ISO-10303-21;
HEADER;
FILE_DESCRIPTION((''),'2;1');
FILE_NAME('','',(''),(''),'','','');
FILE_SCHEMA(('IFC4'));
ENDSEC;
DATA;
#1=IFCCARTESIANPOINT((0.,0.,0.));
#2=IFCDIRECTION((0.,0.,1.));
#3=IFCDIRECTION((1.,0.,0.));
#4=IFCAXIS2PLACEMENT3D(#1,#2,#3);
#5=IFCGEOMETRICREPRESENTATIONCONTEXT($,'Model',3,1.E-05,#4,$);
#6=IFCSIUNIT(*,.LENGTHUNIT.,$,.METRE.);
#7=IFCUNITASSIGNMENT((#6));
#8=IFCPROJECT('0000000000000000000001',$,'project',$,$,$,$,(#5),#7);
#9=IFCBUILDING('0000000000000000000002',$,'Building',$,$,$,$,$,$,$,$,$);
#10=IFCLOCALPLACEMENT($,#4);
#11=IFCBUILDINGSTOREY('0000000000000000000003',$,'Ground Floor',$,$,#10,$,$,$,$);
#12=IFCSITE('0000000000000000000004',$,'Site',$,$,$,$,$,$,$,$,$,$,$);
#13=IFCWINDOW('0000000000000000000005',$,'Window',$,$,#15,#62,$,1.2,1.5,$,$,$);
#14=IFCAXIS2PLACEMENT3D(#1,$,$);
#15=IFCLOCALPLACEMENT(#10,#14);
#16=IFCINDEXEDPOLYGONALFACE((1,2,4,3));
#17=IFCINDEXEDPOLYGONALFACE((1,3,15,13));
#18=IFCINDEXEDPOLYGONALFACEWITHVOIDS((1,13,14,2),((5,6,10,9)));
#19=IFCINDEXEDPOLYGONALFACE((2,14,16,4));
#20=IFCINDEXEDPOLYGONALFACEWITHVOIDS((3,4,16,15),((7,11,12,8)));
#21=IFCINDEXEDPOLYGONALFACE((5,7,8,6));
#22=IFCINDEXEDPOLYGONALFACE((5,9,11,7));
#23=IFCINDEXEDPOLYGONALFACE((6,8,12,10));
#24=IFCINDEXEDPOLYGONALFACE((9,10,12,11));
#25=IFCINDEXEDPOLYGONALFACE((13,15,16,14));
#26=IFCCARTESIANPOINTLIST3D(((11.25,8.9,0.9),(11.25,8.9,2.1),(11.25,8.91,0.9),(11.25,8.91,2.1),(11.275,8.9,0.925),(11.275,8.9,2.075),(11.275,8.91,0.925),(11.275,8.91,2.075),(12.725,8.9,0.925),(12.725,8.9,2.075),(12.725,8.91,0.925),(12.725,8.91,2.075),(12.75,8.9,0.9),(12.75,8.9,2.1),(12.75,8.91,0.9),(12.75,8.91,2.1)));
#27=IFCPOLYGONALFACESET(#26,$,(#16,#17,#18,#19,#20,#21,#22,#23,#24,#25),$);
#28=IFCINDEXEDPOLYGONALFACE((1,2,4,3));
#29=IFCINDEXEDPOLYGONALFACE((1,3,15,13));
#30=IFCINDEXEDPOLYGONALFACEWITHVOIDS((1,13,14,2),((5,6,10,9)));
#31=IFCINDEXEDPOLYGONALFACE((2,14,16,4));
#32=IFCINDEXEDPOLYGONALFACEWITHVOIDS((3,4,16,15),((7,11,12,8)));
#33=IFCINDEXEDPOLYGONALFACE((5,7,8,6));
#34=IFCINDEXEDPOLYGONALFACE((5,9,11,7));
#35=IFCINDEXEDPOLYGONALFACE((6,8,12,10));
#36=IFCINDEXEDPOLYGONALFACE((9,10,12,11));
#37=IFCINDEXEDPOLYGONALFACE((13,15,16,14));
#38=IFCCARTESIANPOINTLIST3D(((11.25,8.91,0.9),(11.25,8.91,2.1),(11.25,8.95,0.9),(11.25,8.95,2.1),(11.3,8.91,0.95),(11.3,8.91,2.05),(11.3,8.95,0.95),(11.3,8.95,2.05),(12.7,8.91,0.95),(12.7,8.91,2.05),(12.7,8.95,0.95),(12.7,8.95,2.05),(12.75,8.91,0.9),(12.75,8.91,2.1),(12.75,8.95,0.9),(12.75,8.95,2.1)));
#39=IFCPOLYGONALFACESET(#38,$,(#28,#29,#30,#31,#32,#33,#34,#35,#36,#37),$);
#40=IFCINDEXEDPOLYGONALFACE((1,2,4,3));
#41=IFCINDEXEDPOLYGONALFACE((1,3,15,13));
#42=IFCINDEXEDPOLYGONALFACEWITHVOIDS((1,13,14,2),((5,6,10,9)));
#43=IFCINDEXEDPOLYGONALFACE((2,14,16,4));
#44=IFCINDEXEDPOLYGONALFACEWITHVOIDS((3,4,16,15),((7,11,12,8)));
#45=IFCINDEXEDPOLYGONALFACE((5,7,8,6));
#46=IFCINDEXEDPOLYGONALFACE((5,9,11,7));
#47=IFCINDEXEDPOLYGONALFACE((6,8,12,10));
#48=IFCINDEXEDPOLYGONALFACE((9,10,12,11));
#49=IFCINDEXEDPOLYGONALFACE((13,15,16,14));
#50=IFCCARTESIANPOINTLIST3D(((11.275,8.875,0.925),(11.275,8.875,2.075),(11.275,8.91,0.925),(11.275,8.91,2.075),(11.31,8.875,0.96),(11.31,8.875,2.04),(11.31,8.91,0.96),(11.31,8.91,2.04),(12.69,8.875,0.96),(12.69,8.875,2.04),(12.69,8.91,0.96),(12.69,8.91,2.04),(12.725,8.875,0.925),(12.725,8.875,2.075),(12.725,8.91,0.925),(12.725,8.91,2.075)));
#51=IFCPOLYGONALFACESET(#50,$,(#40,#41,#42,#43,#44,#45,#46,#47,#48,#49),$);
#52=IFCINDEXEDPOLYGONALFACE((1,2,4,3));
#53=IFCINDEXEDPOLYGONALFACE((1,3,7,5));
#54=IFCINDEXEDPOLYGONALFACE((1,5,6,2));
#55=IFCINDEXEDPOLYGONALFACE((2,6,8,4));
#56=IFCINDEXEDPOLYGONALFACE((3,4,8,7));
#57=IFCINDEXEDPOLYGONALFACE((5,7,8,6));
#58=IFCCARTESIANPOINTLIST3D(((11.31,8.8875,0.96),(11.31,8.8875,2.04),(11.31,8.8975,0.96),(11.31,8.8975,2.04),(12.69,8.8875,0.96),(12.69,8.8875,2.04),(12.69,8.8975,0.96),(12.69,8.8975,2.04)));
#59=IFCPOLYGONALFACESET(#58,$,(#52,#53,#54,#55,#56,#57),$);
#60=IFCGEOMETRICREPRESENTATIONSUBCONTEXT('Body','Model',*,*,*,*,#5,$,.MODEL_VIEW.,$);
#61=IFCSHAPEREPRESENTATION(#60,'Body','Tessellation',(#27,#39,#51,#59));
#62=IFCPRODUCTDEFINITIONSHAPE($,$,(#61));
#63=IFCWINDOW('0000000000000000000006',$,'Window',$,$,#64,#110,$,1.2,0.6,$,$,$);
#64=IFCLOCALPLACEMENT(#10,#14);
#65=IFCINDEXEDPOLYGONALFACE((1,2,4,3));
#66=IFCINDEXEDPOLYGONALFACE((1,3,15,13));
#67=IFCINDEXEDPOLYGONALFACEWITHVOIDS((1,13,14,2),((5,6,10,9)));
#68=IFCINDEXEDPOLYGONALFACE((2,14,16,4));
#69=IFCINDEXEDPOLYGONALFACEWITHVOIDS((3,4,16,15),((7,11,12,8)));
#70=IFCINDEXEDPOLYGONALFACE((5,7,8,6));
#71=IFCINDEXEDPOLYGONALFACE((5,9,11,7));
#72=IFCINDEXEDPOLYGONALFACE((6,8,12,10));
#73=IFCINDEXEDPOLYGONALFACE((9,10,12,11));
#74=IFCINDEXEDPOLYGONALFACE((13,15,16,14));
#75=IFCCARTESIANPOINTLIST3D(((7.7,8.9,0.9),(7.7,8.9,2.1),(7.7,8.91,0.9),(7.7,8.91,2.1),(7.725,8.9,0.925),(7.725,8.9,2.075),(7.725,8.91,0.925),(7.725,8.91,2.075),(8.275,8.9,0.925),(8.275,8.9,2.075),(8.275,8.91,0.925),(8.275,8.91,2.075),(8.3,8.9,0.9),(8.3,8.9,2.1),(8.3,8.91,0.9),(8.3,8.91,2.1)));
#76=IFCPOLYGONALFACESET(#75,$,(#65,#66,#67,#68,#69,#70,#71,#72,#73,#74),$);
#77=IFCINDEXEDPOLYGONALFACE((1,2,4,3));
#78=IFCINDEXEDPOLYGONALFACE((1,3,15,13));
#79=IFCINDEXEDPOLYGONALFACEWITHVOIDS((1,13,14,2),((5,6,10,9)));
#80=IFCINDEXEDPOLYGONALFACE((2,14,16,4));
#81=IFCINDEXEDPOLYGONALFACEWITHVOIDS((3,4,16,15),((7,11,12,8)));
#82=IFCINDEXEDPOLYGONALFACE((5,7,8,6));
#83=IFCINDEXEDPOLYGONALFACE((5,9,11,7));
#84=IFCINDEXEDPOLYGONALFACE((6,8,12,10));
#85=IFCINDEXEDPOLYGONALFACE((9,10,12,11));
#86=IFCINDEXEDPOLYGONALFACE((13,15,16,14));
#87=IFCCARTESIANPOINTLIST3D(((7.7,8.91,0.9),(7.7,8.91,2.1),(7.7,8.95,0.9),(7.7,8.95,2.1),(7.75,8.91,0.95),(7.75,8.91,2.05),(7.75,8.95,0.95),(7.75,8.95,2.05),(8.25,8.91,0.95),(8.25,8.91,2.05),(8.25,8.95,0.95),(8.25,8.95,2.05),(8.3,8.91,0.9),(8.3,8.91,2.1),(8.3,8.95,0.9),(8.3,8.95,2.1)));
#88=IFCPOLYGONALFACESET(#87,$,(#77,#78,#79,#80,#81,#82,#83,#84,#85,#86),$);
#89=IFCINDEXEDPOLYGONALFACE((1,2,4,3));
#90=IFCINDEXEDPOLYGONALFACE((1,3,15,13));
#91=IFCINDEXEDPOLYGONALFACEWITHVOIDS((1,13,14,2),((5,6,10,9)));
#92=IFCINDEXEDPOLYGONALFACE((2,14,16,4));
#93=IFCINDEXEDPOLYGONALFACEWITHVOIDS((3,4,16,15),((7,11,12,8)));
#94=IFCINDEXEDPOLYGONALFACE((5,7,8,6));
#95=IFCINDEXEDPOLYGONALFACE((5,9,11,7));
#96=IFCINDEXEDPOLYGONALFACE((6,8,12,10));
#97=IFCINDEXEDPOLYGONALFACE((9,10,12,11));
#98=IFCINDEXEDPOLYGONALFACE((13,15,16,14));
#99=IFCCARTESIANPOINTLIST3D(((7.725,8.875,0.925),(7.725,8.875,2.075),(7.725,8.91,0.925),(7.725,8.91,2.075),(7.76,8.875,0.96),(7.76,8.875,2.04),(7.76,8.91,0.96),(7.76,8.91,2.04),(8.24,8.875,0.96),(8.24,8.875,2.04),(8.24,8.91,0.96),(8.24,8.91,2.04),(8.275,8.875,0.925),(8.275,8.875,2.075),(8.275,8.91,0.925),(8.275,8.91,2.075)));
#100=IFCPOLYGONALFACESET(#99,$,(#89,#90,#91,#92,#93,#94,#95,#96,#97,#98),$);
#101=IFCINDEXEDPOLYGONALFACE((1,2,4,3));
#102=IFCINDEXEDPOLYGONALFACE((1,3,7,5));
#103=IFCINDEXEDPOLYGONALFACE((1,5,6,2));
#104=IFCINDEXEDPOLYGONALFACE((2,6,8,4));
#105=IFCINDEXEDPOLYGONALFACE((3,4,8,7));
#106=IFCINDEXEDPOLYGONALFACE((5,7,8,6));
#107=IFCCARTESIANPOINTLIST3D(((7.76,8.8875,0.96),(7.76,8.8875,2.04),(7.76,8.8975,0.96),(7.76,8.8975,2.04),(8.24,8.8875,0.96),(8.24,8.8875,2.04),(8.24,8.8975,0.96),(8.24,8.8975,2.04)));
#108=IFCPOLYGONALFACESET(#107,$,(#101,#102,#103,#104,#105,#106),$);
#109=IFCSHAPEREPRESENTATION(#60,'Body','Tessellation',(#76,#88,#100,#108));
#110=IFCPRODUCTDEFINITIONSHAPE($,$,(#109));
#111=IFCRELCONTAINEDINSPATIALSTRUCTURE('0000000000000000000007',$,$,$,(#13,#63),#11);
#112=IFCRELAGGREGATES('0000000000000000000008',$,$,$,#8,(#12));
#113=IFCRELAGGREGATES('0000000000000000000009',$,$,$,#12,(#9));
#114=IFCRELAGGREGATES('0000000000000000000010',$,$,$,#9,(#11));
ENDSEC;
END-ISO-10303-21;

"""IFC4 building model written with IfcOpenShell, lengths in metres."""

from ifc_helpers import new_model, si_unit, frame, origin_with_axes, place, context, subcontext, project, spatial, line, indexed_curve, outline, extrude, element, save


model = new_model("IFC4")

# Units and contexts
model_context = context("Model", 3, precision=1e-05, world=origin_with_axes())
body_context = subcontext(model_context, "Body", "Model", "MODEL_VIEW")
ifc_project = project(units=[si_unit("LENGTHUNIT", "METRE")], contexts=[model_context])

# Site, building, storey
site = spatial("IfcSite", under=ifc_project, Name="Site")
building = spatial("IfcBuilding", under=site, Name="Building")
storey_placement = place(None, origin_with_axes())
storey = spatial("IfcBuildingStorey", under=building, at=storey_placement, Name="Ground Floor")

# Windows
window_1_placement = place(storey_placement, frame((12.75, 9.0, 0.9), z_axis=(0.0, 0.0, 1.0), x_axis=(-1.0, 0.0, 0.0)))
element("IfcWindow", 1, at=window_1_placement, inside=storey, Name="Window", OverallHeight=1.2, OverallWidth=1.5, context=body_context, shape_type="SweptSolid", body=[
    extrude(outline(indexed_curve([(0.0, 0.0), (1.5, 0.0), (1.5, 1.2), (0.0, 1.2)], segments=[line(1, 2, 3, 4, 1)]), holes=[indexed_curve([(0.025, 0.025), (1.475, 0.025), (1.475, 1.175), (0.025, 1.175)], segments=[line(1, 2, 3, 4, 1)])]), frame((0.0, 0.09, 0.0), z_axis=(0.0, -1.0, 0.0), x_axis=(1.0, 0.0, 0.0)), (0.0, 0.0, -1.0), 0.01),
    extrude(outline(indexed_curve([(0.0, 0.0), (1.5, 0.0), (1.5, 1.2), (0.0, 1.2)], segments=[line(1, 2, 3, 4, 1)]), holes=[indexed_curve([(0.05, 0.05), (1.45, 0.05), (1.45, 1.15), (0.05, 1.15)], segments=[line(1, 2, 3, 4, 1)])]), frame((0.0, 0.05, 0.0), z_axis=(0.0, -1.0, 0.0), x_axis=(1.0, 0.0, 0.0)), (0.0, 0.0, -1.0), 0.04),
    extrude(outline(indexed_curve([(0.0, 0.0), (1.45, 0.0), (1.45, 1.15), (0.0, 1.15)], segments=[line(1, 2, 3, 4, 1)]), holes=[indexed_curve([(0.035, 0.035), (1.415, 0.035), (1.415, 1.115), (0.035, 1.115)], segments=[line(1, 2, 3, 4, 1)])]), frame((0.025, 0.09, 0.025), z_axis=(0.0, -1.0, 0.0), x_axis=(1.0, 0.0, 0.0)), (0.0, 0.0, -1.0), 0.035),
    extrude(outline(indexed_curve([(0.035, 0.035), (1.415, 0.035), (1.415, 1.115), (0.035, 1.115)], segments=[line(1, 2, 3, 4, 1)])), frame((0.025, 0.1025, 0.025), z_axis=(0.0, -1.0, 0.0), x_axis=(1.0, 0.0, 0.0)), (0.0, 0.0, -1.0), 0.01),
])
window_2_placement = place(storey_placement, frame((8.3, 9.0, 0.9), z_axis=(0.0, 0.0, 1.0), x_axis=(-1.0, 0.0, 0.0)))
element("IfcWindow", 2, at=window_2_placement, inside=storey, Name="Window", OverallHeight=1.2, OverallWidth=0.6, context=body_context, shape_type="SweptSolid", body=[
    extrude(outline(indexed_curve([(0.0, 0.0), (0.6, 0.0), (0.6, 1.2), (0.0, 1.2)], segments=[line(1, 2, 3, 4, 1)]), holes=[indexed_curve([(0.025, 0.025), (0.575, 0.025), (0.575, 1.175), (0.025, 1.175)], segments=[line(1, 2, 3, 4, 1)])]), frame((0.0, 0.09, 0.0), z_axis=(0.0, -1.0, 0.0), x_axis=(1.0, 0.0, 0.0)), (0.0, 0.0, -1.0), 0.01),
    extrude(outline(indexed_curve([(0.0, 0.0), (0.6, 0.0), (0.6, 1.2), (0.0, 1.2)], segments=[line(1, 2, 3, 4, 1)]), holes=[indexed_curve([(0.05, 0.05), (0.55, 0.05), (0.55, 1.15), (0.05, 1.15)], segments=[line(1, 2, 3, 4, 1)])]), frame((0.0, 0.05, 0.0), z_axis=(0.0, -1.0, 0.0), x_axis=(1.0, 0.0, 0.0)), (0.0, 0.0, -1.0), 0.04),
    extrude(outline(indexed_curve([(0.0, 0.0), (0.55, 0.0), (0.55, 1.15), (0.0, 1.15)], segments=[line(1, 2, 3, 4, 1)]), holes=[indexed_curve([(0.035, 0.035), (0.515, 0.035), (0.515, 1.115), (0.035, 1.115)], segments=[line(1, 2, 3, 4, 1)])]), frame((0.025, 0.09, 0.025), z_axis=(0.0, -1.0, 0.0), x_axis=(1.0, 0.0, 0.0)), (0.0, 0.0, -1.0), 0.035),
    extrude(outline(indexed_curve([(0.035, 0.035), (0.515, 0.035), (0.515, 1.115), (0.035, 1.115)], segments=[line(1, 2, 3, 4, 1)])), frame((0.025, 0.1025, 0.025), z_axis=(0.0, -1.0, 0.0), x_axis=(1.0, 0.0, 0.0)), (0.0, 0.0, -1.0), 0.01),
])

save(model, "model.ifc")
